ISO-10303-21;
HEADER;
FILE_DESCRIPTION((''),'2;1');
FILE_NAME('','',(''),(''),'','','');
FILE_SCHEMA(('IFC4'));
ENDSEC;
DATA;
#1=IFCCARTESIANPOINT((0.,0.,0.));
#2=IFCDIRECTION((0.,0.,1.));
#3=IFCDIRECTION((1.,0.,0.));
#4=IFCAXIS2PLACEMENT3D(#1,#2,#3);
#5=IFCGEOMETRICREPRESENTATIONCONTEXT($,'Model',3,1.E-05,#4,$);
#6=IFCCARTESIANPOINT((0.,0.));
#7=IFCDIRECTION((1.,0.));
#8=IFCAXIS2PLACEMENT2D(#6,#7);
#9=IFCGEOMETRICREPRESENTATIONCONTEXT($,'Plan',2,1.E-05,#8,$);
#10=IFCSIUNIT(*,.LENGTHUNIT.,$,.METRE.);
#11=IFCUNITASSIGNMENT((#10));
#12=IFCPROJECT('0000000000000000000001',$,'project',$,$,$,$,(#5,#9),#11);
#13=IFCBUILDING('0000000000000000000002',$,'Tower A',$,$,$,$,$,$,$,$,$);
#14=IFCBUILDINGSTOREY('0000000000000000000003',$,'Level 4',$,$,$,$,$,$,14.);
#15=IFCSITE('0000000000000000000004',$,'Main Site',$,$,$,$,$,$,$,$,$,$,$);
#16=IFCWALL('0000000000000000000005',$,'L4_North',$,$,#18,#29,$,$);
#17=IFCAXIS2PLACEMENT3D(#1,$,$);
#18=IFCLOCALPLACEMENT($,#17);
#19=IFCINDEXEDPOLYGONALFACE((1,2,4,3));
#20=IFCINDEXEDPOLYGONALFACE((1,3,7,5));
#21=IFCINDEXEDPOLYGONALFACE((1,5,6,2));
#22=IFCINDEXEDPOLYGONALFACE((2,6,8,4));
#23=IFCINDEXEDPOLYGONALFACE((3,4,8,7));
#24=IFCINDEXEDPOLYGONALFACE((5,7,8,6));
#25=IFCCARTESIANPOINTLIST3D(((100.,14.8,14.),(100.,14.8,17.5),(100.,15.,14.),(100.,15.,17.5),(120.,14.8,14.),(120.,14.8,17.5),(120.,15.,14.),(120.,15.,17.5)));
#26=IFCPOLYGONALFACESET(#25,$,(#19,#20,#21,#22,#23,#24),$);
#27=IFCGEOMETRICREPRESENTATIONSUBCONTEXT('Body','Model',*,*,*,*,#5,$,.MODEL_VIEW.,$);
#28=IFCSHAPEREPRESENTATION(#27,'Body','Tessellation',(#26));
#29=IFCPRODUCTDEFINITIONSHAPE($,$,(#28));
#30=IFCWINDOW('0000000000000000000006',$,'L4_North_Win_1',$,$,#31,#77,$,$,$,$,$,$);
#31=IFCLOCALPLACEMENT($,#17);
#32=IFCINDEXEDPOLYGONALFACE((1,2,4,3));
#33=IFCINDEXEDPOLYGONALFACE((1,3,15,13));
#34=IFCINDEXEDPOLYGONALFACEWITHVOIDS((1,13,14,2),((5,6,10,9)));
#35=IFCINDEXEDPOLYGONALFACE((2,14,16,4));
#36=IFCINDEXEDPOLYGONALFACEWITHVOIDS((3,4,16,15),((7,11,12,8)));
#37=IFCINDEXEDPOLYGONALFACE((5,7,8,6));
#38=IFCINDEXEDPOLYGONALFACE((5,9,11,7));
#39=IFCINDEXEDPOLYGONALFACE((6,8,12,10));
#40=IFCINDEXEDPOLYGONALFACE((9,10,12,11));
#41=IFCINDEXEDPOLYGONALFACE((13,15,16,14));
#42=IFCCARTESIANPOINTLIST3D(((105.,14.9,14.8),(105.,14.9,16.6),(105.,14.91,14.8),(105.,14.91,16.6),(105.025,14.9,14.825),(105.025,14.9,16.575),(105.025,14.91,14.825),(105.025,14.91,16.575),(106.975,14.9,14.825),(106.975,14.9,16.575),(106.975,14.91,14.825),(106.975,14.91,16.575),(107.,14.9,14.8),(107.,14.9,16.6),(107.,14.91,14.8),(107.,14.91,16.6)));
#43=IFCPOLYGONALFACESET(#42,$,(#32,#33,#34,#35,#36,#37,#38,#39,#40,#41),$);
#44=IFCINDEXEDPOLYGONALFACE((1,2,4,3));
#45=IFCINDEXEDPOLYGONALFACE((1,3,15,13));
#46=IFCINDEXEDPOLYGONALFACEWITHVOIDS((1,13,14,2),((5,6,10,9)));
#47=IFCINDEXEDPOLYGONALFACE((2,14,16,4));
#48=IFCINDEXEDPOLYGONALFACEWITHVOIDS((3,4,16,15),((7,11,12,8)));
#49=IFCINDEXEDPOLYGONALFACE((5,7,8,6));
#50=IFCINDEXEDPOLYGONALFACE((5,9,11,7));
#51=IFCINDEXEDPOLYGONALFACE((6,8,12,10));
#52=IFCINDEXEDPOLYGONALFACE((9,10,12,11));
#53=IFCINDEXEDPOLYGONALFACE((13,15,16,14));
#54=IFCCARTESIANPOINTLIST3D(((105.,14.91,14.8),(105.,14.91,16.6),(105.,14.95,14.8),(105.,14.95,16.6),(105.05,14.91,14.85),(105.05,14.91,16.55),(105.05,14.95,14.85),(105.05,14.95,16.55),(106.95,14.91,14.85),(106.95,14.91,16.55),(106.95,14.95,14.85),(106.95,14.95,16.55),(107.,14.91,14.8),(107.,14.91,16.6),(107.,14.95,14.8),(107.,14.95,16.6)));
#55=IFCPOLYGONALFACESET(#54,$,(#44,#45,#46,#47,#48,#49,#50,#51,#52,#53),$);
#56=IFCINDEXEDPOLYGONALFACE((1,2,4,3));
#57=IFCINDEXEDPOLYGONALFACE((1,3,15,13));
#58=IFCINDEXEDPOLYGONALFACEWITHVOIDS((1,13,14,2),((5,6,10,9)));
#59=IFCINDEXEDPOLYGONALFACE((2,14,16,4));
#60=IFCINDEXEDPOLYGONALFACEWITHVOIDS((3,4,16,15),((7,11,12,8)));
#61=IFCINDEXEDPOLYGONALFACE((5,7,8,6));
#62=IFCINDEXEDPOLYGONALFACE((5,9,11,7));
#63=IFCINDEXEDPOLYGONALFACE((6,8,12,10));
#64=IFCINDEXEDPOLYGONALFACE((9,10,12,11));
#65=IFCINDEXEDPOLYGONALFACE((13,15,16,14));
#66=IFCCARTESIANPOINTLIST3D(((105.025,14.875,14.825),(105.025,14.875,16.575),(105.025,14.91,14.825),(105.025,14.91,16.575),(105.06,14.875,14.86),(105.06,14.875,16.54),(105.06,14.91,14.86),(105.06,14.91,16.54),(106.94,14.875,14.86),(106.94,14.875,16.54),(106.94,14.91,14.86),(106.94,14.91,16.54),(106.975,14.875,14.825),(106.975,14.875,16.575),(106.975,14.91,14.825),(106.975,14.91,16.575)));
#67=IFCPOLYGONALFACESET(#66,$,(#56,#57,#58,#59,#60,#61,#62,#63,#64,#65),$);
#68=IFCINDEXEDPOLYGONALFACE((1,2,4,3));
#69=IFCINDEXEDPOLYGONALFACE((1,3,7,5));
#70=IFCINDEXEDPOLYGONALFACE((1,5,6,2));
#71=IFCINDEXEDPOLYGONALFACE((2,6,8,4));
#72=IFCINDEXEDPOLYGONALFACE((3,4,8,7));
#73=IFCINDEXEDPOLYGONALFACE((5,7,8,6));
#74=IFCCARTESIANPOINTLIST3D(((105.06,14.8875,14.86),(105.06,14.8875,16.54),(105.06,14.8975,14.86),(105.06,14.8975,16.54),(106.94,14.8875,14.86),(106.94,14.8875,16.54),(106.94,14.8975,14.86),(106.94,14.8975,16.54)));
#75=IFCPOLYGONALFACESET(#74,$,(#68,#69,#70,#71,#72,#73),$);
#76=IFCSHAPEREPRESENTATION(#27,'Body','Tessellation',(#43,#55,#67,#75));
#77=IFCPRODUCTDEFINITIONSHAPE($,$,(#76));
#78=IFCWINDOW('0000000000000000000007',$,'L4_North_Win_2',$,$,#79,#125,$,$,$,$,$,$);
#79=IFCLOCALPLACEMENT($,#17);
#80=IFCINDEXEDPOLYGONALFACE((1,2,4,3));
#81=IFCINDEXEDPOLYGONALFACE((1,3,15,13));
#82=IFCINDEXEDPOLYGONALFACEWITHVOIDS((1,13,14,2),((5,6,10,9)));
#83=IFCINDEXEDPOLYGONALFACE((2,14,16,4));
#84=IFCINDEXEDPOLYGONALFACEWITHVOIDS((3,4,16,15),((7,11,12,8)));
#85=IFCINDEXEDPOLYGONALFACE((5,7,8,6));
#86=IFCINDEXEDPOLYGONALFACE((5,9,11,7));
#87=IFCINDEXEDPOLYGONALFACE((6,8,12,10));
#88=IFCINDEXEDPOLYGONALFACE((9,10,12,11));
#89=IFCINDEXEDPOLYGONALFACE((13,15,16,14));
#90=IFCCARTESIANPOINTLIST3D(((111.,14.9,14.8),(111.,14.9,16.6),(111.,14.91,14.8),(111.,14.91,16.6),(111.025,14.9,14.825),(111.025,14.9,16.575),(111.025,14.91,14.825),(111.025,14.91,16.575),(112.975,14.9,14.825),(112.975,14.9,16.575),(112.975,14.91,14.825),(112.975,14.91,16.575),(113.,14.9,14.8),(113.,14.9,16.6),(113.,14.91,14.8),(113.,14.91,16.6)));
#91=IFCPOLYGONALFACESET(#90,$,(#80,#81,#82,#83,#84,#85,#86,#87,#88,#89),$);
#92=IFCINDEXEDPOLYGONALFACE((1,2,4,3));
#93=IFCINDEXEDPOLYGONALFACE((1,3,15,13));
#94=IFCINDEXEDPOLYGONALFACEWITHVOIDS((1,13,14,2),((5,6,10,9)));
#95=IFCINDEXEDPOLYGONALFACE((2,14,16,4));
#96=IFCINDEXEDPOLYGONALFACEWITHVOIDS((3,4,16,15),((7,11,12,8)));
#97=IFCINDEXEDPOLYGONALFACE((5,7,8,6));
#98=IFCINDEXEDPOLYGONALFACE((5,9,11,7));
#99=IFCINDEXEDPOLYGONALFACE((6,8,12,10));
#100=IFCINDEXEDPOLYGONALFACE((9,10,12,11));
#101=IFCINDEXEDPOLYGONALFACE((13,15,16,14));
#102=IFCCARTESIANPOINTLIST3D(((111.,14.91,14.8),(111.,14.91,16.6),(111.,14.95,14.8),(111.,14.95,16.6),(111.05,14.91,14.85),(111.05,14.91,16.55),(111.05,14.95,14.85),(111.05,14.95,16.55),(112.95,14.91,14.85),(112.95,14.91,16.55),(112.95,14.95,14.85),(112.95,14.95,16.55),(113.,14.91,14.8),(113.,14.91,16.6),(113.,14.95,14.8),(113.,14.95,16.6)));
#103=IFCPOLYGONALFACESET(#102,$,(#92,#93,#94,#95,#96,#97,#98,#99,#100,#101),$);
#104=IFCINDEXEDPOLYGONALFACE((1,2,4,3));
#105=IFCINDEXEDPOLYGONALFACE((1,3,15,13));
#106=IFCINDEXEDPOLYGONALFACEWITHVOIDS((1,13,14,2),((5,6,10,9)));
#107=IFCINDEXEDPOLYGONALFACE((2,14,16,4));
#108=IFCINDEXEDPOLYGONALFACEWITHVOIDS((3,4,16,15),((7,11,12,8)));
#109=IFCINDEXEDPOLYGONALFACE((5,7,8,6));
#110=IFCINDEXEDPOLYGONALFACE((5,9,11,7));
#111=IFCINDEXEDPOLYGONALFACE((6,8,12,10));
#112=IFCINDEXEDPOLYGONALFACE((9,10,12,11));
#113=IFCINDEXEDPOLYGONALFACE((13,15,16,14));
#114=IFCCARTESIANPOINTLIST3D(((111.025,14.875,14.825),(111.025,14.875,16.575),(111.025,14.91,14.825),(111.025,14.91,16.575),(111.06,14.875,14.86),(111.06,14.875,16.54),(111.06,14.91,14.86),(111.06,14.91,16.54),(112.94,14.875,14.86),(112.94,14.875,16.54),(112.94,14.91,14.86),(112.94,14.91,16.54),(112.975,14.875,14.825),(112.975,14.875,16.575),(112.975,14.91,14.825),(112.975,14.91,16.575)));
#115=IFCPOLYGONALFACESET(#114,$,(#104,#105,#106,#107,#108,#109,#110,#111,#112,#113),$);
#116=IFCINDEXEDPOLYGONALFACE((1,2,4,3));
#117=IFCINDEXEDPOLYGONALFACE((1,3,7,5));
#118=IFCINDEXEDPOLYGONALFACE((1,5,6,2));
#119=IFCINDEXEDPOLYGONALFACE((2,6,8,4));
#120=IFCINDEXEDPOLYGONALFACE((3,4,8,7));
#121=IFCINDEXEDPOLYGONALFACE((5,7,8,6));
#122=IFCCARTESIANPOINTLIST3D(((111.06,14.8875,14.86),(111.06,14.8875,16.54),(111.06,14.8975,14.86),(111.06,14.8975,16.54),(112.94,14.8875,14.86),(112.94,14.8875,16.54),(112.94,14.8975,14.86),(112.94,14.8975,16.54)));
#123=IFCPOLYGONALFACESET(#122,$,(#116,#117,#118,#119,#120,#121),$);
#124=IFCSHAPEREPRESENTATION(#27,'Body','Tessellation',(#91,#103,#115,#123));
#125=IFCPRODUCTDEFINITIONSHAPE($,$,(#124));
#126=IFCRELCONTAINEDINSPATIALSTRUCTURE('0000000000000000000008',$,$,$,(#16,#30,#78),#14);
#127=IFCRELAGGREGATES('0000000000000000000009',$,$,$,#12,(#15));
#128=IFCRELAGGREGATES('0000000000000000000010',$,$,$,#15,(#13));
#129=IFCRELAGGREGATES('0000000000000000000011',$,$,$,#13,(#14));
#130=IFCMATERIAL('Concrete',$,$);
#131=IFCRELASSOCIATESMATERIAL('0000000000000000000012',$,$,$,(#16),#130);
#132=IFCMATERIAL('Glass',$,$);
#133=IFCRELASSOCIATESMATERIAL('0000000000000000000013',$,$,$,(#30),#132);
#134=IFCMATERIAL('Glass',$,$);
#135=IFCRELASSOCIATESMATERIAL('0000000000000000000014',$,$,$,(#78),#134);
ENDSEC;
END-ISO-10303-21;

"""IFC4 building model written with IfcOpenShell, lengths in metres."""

from ifc_helpers import new_model, si_unit, frame, origin_with_axes, origin_2d_with_axis, place, context, subcontext, project, spatial, line, indexed_curve, outline, extrude, material, element, fill, save


model = new_model("IFC4")

# Units and contexts
model_context = context("Model", 3, precision=1e-05, world=origin_with_axes())
plan_context = context("Plan", 2, precision=1e-05, world=origin_2d_with_axis())
body_context = subcontext(model_context, "Body", "Model", "MODEL_VIEW")
ifc_project = project(units=[si_unit("LENGTHUNIT", "METRE")], contexts=[model_context, plan_context])

# Site, building, storey
site = spatial("IfcSite", under=ifc_project, Name="Main Site")
building = spatial("IfcBuilding", under=site, Name="Tower A")
storey = spatial("IfcBuildingStorey", under=building, Name="Level 4", Elevation=14.0)

# Wall, openings, windows
ifc_material_1 = material(Name="Concrete")
wall_1_placement = place(None, frame((120.0, 15.0, 14.0), z_axis=(0.0, 0.0, 1.0), x_axis=(-1.0, 0.0, 0.0)))
wall_1 = element("IfcWall", 1, at=wall_1_placement, inside=storey, material=ifc_material_1, Name="L4_North", context=body_context, shape_type="SweptSolid", body=[
    extrude(outline(indexed_curve([(0.0, 0.0), (0.0, 0.2), (20.0, 0.2), (20.0, 0.0), (0.0, 0.0)], self_intersect=False)), origin_with_axes(), (0.0, 0.0, 1.0), 3.5),
])
opening_1_placement = place(wall_1_placement, frame((13.0, 0.0, 0.8), z_axis=(0.0, 0.0, 1.0), x_axis=(-1.0, 0.0, 0.0)))
opening_1 = element("IfcOpeningElement", 2, at=opening_1_placement, cuts=wall_1, context=body_context, shape_type="SweptSolid", body=[
    extrude(outline(indexed_curve([(0.0, 0.0), (0.0, 0.25), (2.0, 0.25), (2.0, 0.0), (0.0, 0.0)], self_intersect=False)), origin_with_axes(), (0.0, 0.0, 1.0), 1.8),
])
opening_2_placement = place(wall_1_placement, frame((7.0, 0.0, 0.8), z_axis=(0.0, 0.0, 1.0), x_axis=(-1.0, 0.0, 0.0)))
opening_2 = element("IfcOpeningElement", 3, at=opening_2_placement, cuts=wall_1, context=body_context, shape_type="SweptSolid", body=[
    extrude(outline(indexed_curve([(0.0, 0.0), (0.0, 0.25), (2.0, 0.25), (2.0, 0.0), (0.0, 0.0)], self_intersect=False)), origin_with_axes(), (0.0, 0.0, 1.0), 1.8),
])
ifc_material_2 = material(Name="Glass")
window_1_placement = place(None, frame((107.0, 15.0, 14.8), z_axis=(0.0, 0.0, 1.0), x_axis=(-1.0, 0.0, 0.0)))
window_1 = element("IfcWindow", 4, at=window_1_placement, inside=storey, material=ifc_material_2, Name="L4_North_Win_1", context=body_context, shape_type="SweptSolid", body=[
    extrude(outline(indexed_curve([(0.0, 0.0), (2.0, 0.0), (2.0, 1.8), (0.0, 1.8)], segments=[line(1, 2, 3, 4, 1)]), holes=[indexed_curve([(0.025, 0.025), (1.975, 0.025), (1.975, 1.775), (0.025, 1.775)], segments=[line(1, 2, 3, 4, 1)])]), frame((0.0, 0.09, 0.0), z_axis=(0.0, -1.0, 0.0), x_axis=(1.0, 0.0, 0.0)), (0.0, 0.0, -1.0), 0.01),
    extrude(outline(indexed_curve([(0.0, 0.0), (2.0, 0.0), (2.0, 1.8), (0.0, 1.8)], segments=[line(1, 2, 3, 4, 1)]), holes=[indexed_curve([(0.05, 0.05), (1.95, 0.05), (1.95, 1.75), (0.05, 1.75)], segments=[line(1, 2, 3, 4, 1)])]), frame((0.0, 0.05, 0.0), z_axis=(0.0, -1.0, 0.0), x_axis=(1.0, 0.0, 0.0)), (0.0, 0.0, -1.0), 0.04),
    extrude(outline(indexed_curve([(0.0, 0.0), (1.95, 0.0), (1.95, 1.75), (0.0, 1.75)], segments=[line(1, 2, 3, 4, 1)]), holes=[indexed_curve([(0.035, 0.035), (1.915, 0.035), (1.915, 1.715), (0.035, 1.715)], segments=[line(1, 2, 3, 4, 1)])]), frame((0.025, 0.09, 0.025), z_axis=(0.0, -1.0, 0.0), x_axis=(1.0, 0.0, 0.0)), (0.0, 0.0, -1.0), 0.035),
    extrude(outline(indexed_curve([(0.035, 0.035), (1.915, 0.035), (1.915, 1.715), (0.035, 1.715)], segments=[line(1, 2, 3, 4, 1)])), frame((0.025, 0.1025, 0.025), z_axis=(0.0, -1.0, 0.0), x_axis=(1.0, 0.0, 0.0)), (0.0, 0.0, -1.0), 0.01),
])
fill(opening_1, window_1)
ifc_material_3 = material(Name="Glass")
window_2_placement = place(None, frame((113.0, 15.0, 14.8), z_axis=(0.0, 0.0, 1.0), x_axis=(-1.0, 0.0, 0.0)))
window_2 = element("IfcWindow", 5, at=window_2_placement, inside=storey, material=ifc_material_3, Name="L4_North_Win_2", context=body_context, shape_type="SweptSolid", body=[
    extrude(outline(indexed_curve([(0.0, 0.0), (2.0, 0.0), (2.0, 1.8), (0.0, 1.8)], segments=[line(1, 2, 3, 4, 1)]), holes=[indexed_curve([(0.025, 0.025), (1.975, 0.025), (1.975, 1.775), (0.025, 1.775)], segments=[line(1, 2, 3, 4, 1)])]), frame((0.0, 0.09, 0.0), z_axis=(0.0, -1.0, 0.0), x_axis=(1.0, 0.0, 0.0)), (0.0, 0.0, -1.0), 0.01),
    extrude(outline(indexed_curve([(0.0, 0.0), (2.0, 0.0), (2.0, 1.8), (0.0, 1.8)], segments=[line(1, 2, 3, 4, 1)]), holes=[indexed_curve([(0.05, 0.05), (1.95, 0.05), (1.95, 1.75), (0.05, 1.75)], segments=[line(1, 2, 3, 4, 1)])]), frame((0.0, 0.05, 0.0), z_axis=(0.0, -1.0, 0.0), x_axis=(1.0, 0.0, 0.0)), (0.0, 0.0, -1.0), 0.04),
    extrude(outline(indexed_curve([(0.0, 0.0), (1.95, 0.0), (1.95, 1.75), (0.0, 1.75)], segments=[line(1, 2, 3, 4, 1)]), holes=[indexed_curve([(0.035, 0.035), (1.915, 0.035), (1.915, 1.715), (0.035, 1.715)], segments=[line(1, 2, 3, 4, 1)])]), frame((0.025, 0.09, 0.025), z_axis=(0.0, -1.0, 0.0), x_axis=(1.0, 0.0, 0.0)), (0.0, 0.0, -1.0), 0.035),
    extrude(outline(indexed_curve([(0.035, 0.035), (1.915, 0.035), (1.915, 1.715), (0.035, 1.715)], segments=[line(1, 2, 3, 4, 1)])), frame((0.025, 0.1025, 0.025), z_axis=(0.0, -1.0, 0.0), x_axis=(1.0, 0.0, 0.0)), (0.0, 0.0, -1.0), 0.01),
])
fill(opening_2, window_2)

save(model, "model.ifc")
